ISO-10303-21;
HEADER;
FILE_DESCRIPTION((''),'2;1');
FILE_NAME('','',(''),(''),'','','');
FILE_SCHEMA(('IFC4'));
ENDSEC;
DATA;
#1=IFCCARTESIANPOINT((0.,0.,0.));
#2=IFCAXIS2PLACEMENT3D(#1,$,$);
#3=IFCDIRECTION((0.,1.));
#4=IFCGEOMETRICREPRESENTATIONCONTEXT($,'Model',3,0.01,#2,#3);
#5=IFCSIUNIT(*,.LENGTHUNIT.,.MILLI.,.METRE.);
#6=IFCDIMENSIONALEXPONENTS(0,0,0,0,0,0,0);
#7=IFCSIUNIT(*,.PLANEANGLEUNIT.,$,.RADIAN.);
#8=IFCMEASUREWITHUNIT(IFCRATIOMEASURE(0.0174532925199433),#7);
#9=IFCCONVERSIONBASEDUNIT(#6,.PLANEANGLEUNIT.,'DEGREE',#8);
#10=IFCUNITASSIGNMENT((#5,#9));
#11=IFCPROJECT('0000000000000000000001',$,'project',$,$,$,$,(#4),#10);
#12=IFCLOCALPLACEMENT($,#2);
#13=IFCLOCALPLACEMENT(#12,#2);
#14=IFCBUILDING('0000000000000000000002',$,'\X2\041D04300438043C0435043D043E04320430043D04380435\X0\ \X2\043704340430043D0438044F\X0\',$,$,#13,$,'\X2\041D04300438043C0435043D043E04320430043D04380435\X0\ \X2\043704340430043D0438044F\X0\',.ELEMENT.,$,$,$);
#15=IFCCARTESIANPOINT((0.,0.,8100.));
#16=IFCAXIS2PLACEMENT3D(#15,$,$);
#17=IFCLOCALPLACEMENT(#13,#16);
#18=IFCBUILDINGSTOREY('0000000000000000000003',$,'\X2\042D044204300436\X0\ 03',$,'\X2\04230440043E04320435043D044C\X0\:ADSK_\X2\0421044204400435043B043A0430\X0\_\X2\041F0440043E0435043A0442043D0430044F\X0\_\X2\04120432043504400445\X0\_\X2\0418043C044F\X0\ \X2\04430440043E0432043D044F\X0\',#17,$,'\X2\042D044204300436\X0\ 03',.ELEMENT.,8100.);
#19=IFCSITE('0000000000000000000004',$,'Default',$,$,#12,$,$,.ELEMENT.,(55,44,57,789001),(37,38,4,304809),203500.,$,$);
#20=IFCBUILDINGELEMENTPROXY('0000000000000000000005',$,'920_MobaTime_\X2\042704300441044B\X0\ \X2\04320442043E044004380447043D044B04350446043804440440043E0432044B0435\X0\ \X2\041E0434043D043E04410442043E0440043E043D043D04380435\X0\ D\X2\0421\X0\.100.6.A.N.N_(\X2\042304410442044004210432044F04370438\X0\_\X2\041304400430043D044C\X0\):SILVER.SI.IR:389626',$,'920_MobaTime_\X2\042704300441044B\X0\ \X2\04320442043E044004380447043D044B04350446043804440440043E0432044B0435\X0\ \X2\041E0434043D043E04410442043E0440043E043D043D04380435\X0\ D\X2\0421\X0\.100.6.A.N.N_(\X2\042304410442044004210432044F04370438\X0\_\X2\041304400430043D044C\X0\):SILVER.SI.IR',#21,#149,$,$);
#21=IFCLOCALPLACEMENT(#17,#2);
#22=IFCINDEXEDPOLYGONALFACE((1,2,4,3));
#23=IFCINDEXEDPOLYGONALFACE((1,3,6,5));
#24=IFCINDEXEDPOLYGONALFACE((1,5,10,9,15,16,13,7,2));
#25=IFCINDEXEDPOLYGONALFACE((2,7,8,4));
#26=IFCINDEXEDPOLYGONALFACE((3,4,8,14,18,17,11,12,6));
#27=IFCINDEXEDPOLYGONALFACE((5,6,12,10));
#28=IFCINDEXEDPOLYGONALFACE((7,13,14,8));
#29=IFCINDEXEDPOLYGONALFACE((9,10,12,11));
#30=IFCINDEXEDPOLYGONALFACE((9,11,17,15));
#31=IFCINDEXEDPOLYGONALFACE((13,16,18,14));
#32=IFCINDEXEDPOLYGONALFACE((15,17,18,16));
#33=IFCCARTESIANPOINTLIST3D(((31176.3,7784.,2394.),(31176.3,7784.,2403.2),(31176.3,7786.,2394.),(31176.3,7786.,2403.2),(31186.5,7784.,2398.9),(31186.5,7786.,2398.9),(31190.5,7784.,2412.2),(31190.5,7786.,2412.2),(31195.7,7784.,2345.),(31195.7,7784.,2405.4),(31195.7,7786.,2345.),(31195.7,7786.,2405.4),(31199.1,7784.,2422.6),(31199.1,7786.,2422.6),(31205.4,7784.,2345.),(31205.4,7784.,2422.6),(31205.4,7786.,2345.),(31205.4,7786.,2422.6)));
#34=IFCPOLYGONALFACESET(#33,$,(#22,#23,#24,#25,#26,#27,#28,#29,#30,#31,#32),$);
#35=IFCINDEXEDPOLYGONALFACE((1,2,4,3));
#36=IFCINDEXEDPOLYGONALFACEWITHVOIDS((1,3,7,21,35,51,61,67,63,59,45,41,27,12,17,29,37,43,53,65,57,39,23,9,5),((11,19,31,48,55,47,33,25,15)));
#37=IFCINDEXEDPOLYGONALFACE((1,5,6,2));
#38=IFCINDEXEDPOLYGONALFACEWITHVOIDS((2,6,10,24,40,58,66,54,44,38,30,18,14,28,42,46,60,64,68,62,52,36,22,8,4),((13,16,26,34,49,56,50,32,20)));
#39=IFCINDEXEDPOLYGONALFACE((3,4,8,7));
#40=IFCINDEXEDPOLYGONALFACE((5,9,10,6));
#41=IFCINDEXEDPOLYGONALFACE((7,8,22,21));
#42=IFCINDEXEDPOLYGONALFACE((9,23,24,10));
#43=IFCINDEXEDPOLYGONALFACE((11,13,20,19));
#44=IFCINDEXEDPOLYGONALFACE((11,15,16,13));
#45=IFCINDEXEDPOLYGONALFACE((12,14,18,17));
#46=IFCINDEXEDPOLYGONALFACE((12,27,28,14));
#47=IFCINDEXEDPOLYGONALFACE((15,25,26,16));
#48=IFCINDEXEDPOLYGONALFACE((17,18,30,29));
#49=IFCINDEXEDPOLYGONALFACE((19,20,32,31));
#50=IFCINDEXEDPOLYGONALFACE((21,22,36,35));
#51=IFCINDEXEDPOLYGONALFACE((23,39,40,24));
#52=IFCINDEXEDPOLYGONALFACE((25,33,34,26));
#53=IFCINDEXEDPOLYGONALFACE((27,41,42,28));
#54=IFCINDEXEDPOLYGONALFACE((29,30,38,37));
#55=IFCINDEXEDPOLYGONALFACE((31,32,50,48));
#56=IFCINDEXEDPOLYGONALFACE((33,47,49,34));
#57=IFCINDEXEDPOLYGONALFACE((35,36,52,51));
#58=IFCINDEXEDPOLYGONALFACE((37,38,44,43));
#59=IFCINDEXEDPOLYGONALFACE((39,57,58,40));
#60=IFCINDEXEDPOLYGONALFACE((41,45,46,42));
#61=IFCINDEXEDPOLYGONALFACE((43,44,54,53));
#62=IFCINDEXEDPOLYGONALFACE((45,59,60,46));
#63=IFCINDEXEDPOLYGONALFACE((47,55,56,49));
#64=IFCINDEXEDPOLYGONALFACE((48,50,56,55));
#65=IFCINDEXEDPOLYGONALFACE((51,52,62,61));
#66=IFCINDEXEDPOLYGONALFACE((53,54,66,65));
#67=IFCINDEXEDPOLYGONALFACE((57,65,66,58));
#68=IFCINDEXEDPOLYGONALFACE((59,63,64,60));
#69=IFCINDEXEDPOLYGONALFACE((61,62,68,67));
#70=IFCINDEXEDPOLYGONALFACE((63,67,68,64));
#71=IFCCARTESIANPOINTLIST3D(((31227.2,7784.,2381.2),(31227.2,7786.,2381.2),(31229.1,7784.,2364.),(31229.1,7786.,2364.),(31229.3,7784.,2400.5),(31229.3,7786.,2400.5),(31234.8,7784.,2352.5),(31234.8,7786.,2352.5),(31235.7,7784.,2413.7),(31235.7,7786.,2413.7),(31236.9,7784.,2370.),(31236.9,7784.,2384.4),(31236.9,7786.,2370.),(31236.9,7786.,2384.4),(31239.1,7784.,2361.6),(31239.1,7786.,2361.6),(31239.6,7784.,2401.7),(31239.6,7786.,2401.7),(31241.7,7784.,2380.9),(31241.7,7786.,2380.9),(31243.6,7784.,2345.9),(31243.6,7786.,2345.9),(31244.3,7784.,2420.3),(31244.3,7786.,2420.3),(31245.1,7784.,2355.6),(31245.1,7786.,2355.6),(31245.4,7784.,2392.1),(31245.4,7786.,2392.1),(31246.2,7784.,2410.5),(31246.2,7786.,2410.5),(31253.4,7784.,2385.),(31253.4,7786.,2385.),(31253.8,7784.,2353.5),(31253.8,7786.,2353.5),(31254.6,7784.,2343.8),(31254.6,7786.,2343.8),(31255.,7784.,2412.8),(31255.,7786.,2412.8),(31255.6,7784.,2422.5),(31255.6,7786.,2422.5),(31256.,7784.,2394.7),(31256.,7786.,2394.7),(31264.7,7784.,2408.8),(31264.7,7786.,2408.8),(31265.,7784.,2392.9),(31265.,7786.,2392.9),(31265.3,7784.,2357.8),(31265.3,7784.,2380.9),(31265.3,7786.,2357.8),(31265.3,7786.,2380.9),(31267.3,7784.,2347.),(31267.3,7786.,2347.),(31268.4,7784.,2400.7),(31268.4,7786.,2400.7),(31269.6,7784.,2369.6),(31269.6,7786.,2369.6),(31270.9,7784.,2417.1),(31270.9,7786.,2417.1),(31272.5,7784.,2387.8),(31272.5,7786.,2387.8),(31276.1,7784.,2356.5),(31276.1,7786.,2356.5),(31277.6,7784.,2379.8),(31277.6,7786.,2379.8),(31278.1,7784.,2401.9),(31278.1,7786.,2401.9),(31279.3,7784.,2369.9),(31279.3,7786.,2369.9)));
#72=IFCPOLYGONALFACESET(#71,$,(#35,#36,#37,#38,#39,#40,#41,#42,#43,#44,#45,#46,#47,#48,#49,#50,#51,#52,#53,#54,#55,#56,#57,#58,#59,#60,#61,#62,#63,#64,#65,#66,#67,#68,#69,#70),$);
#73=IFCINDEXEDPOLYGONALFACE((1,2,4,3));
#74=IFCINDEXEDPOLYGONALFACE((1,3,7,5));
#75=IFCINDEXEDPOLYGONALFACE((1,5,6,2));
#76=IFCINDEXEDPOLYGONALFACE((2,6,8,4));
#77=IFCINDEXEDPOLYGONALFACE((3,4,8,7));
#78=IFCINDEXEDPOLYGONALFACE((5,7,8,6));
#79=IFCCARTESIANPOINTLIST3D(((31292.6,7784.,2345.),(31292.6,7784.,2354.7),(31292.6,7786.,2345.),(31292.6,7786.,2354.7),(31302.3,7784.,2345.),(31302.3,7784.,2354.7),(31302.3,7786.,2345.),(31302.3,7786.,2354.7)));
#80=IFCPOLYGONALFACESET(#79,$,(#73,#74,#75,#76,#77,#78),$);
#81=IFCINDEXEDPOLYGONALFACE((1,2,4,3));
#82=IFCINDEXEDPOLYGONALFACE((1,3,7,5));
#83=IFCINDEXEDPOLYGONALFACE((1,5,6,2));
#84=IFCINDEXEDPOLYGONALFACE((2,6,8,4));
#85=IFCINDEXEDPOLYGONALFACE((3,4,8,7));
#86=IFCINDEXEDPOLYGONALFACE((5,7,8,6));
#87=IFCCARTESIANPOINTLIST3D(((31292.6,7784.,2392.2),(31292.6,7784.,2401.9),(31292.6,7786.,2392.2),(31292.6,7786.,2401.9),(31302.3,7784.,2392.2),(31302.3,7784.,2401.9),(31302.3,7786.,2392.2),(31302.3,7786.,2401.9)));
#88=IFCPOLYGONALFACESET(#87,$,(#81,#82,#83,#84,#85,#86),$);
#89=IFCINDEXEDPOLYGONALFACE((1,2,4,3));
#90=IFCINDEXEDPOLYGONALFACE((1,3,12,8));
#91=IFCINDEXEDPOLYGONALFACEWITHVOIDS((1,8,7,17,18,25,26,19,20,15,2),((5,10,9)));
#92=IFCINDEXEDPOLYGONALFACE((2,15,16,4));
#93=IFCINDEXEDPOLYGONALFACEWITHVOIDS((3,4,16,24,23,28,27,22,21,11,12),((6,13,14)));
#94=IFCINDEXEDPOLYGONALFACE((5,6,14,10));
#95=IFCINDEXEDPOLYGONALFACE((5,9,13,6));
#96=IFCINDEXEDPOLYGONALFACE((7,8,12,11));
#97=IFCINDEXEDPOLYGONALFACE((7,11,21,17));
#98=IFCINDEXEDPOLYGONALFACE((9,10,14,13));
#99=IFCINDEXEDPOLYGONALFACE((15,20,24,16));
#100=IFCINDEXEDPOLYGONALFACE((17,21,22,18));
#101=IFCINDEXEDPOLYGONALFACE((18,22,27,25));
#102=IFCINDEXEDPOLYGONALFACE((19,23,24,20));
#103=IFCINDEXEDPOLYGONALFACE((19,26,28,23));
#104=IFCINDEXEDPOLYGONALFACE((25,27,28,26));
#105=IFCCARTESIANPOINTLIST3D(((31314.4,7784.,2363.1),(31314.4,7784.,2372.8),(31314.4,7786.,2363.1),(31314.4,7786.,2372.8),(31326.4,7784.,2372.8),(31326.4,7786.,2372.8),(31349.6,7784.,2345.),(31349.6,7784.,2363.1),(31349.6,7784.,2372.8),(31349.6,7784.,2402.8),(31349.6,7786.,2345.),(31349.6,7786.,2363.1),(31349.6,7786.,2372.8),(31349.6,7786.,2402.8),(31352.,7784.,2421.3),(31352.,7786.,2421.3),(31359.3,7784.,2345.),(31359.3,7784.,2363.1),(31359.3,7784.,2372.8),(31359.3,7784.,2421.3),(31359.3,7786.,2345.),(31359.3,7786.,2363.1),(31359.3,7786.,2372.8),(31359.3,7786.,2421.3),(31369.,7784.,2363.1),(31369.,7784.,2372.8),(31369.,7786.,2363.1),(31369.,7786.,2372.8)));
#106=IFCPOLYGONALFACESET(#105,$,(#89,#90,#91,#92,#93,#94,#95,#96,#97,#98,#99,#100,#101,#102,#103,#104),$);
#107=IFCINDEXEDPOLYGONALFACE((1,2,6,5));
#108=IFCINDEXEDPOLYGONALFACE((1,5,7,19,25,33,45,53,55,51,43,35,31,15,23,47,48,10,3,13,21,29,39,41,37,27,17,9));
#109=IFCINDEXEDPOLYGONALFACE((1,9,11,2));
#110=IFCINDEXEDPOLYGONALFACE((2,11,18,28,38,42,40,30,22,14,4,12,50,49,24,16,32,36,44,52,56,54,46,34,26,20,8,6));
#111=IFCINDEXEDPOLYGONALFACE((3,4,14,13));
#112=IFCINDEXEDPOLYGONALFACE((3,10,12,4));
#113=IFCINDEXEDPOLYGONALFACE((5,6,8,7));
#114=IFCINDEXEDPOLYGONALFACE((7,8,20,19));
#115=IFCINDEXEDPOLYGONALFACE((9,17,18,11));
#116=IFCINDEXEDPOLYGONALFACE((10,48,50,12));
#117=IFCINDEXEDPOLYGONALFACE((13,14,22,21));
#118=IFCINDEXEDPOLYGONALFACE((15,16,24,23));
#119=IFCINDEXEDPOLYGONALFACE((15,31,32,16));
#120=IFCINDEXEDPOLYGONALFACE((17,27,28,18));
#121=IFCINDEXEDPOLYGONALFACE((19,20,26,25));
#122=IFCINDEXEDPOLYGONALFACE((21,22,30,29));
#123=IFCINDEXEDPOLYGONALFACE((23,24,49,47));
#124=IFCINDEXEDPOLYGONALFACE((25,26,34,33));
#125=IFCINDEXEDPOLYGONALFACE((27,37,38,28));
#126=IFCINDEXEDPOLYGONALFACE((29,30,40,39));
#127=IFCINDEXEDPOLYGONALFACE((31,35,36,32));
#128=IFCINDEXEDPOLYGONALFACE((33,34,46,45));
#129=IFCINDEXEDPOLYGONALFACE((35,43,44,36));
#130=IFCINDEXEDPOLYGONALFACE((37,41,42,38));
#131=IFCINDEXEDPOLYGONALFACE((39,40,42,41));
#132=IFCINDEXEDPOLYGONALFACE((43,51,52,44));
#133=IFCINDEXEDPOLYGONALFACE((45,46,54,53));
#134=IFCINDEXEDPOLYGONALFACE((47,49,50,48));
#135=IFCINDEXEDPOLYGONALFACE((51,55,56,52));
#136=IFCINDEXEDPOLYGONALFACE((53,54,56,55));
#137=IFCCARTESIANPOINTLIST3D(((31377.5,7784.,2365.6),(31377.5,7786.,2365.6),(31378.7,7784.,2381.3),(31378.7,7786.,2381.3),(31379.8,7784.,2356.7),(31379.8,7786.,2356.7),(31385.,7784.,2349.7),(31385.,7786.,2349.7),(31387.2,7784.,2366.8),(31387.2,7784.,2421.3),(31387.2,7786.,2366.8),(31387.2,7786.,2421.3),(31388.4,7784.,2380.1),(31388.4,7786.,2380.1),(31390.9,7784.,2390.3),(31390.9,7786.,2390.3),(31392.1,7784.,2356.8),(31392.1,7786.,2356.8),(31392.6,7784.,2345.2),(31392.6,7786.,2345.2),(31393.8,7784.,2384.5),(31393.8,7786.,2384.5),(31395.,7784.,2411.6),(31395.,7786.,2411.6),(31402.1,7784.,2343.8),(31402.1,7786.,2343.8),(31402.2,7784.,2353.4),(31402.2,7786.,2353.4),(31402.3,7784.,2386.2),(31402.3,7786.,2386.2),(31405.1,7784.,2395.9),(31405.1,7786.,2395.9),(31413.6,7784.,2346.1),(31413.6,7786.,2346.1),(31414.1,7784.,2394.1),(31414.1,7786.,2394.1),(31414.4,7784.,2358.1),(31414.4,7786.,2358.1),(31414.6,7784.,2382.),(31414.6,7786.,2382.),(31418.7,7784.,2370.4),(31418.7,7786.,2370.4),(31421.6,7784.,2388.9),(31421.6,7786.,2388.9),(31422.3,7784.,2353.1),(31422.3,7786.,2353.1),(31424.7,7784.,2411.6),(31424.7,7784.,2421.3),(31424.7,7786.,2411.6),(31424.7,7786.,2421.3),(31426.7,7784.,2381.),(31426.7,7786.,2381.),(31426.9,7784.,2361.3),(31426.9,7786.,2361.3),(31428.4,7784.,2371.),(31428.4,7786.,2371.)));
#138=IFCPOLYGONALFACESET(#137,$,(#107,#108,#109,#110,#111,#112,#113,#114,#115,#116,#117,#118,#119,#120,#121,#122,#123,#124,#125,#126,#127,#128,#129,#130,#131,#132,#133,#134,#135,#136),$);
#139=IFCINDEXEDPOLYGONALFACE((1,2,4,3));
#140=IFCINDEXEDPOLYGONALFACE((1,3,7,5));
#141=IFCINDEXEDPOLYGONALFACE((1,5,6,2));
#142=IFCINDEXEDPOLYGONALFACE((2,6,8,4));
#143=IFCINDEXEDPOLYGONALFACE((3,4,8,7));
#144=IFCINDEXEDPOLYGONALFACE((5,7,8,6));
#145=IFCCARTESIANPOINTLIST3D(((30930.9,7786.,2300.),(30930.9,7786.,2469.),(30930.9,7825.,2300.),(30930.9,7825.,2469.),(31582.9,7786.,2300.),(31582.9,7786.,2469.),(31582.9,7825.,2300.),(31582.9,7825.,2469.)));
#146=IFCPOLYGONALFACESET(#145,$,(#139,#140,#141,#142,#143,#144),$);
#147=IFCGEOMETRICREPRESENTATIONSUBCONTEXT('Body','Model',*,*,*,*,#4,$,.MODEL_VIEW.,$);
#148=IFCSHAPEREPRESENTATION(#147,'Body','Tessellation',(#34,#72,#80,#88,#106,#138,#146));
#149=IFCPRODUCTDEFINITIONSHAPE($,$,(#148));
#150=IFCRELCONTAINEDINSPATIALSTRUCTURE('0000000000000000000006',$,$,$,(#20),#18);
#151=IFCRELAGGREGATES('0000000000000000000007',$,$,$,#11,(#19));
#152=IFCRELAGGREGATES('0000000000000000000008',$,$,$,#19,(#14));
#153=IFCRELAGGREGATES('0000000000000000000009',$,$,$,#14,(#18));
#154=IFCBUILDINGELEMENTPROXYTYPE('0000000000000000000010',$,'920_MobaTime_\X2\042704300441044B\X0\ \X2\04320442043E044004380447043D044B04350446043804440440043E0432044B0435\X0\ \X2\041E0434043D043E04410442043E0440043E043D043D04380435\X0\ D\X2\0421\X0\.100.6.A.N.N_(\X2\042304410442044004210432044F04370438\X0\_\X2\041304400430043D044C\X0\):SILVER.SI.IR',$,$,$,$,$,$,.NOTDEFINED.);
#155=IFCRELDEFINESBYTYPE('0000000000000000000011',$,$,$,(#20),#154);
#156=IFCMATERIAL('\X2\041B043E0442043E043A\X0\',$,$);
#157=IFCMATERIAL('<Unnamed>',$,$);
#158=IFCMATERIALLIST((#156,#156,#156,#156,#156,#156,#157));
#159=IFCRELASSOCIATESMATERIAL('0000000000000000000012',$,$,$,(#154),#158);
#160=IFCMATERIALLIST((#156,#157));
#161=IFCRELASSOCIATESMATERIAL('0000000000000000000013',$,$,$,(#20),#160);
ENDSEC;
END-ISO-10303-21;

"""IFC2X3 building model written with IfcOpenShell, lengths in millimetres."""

from ifc_helpers import new_model, entity, si_unit, converted_unit, direction, frame, origin, origin_2d_with_axis, place, context, subcontext, project, spatial, polyline, rectangle, outline, extrude, source, transform, mapped, material, material_list, type_object, type_shapes, element, save


model = new_model("IFC2X3")

# Units and contexts
model_context = context("Model", 3, precision=0.01, world=origin(), true_north=direction((0.0, 1.0)))
body_context = subcontext(model_context, "Body", "Model", "MODEL_VIEW")
ifc_project = project(units=[si_unit("LENGTHUNIT", "METRE", prefix="MILLI"), converted_unit("PLANEANGLEUNIT", "DEGREE", entity("IfcRatioMeasure", 0.0174532925199433), si_unit("PLANEANGLEUNIT", "RADIAN"), dimensions=[0, 0, 0, 0, 0, 0, 0])], contexts=[model_context])

# Site, building, storey
site_placement = place(None, origin())
site = spatial("IfcSite", under=ifc_project, at=site_placement, Name="Default", CompositionType="ELEMENT", RefLatitude=(55, 44, 57, 789001), RefLongitude=(37, 38, 4, 304809), RefElevation=203500.0)
building_placement = place(site_placement, origin())
building = spatial("IfcBuilding", under=site, at=building_placement, Name="Наименование здания", LongName="Наименование здания", CompositionType="ELEMENT")
storey_placement = place(building_placement, frame((0.0, 0.0, 8100.0)))
storey = spatial("IfcBuildingStorey", under=building, at=storey_placement, Name="Этаж 03", ObjectType="Уровень:ADSK_Стрелка_Проектная_Вверх_Имя уровня", LongName="Этаж 03", CompositionType="ELEMENT", Elevation=8100.0)

# Building element proxy
ifc_material_1 = material(Name="Лоток")
ifc_material_2 = material(Name="<Unnamed>")
ifc_material_list_1 = material_list([ifc_material_1, ifc_material_1, ifc_material_1, ifc_material_1, ifc_material_1, ifc_material_1, ifc_material_2])
building_element_proxy_type = type_object("IfcBuildingElementProxyType", Name="920_MobaTime_Часы вторичныецифровые Односторонние DС.100.6.A.N.N_(УстрСвязи_Грань):SILVER.SI.IR", PredefinedType="NOTDEFINED", material=ifc_material_list_1)
shared_shape = source(origin(), body_context, "Body", "SweptSolid", [
    extrude(outline(polyline([(-49.3, -13.1), (28.2, -13.1), (28.2, -6.8), (17.9, 1.8), (8.8, 16.0), (-0.3, 16.0), (4.6, 5.8), (11.1, -3.4), (-49.3, -3.4), (-49.3, -13.1)])), frame((-64.6, 9.8, 39.0), z_axis=(0.0, 0.0, 1.0), x_axis=(0.0, 1.0, 0.0)), (0.0, 0.0, 1.0), 2.0),
    extrude(outline(polyline([(2.2, -27.6), (19.0, -27.6), (30.5, -16.1), (33.3, -4.9), (31.0, 5.8), (21.8, 17.2), (5.2, 27.3), (-11.1, 33.0), (-24.0, 32.7), (-33.6, 27.6), (-40.3, 18.6), (-42.8, 5.7), (-38.0, -6.3), (-27.2, -14.9), (-17.5, -17.7), (-8.2, -16.4), (-0.3, -11.9), (5.1, -4.5), (7.3, 6.2), (4.0, 17.2), (18.4, 7.3), (23.6, -2.4), (22.0, -11.4), (14.2, -18.4), (5.3, -18.3), (2.2, -27.6)]), holes=[polyline([(-9.0, 23.3), (-1.3, 14.3), (-2.5, 2.0), (-11.4, -7.0), (-23.4, -6.0), (-32.2, 2.9), (-31.2, 15.1), (-25.6, 22.1), (-17.5, 24.9), (-9.0, 23.3)])]), frame((-2.7, 3.6, 39.0), z_axis=(0.0, 0.0, 1.0), x_axis=(-0.427649, 0.903945, 0.0)), (0.0, 0.0, 1.0), 2.0),
    extrude(rectangle(XDim=9.7, YDim=9.7, at=origin_2d_with_axis()), frame((40.6, -34.7, 39.0)), (0.0, 0.0, 1.0), 2.0),
    extrude(rectangle(XDim=9.7, YDim=9.7, at=origin_2d_with_axis()), frame((40.6, 12.6, 39.0)), (0.0, 0.0, 1.0), 2.0),
    extrude(outline(polyline([(-0.9, -28.1), (8.8, -28.1), (8.8, -9.9), (18.5, -9.9), (18.5, -0.2), (8.8, -0.2), (8.8, 48.3), (1.5, 48.3), (-36.0, -0.2), (-36.0, -9.9), (-0.9, -9.9), (-0.9, -28.1)]), holes=[polyline([(-0.9, -0.2), (-24.1, -0.2), (-0.9, 29.7), (-0.9, -0.2)])]), frame((93.6, -11.4, 39.0)), (0.0, 0.0, 1.0), 2.0),
    extrude(outline(polyline([(3.3, -28.3), (12.5, -28.3), (20.5, -25.0), (26.8, -18.9), (30.7, -10.0), (31.4, 1.6), (26.9, 11.8), (20.1, 18.4), (11.1, 22.3), (1.0, 23.3), (-7.9, 20.4), (-14.9, 14.5), (-18.9, 6.2), (-17.1, -9.0), (-36.7, 0.5), (-29.1, 29.2), (-38.5, 31.7), (-48.1, -4.6), (-11.6, -23.1), (-8.0, -14.0), (-10.8, -7.6), (-10.2, 1.1), (-3.0, 11.8), (9.2, 12.8), (20.0, 5.5), (21.4, -7.5), (15.5, -16.4), (4.6, -18.6), (3.3, -28.3)])), frame((147.1, -8.5, 39.0), z_axis=(0.0, 0.0, 1.0), x_axis=(0.256974, -0.966418, 0.0)), (0.0, 0.0, 1.0), 2.0),
    extrude(rectangle(XDim=652.0, YDim=169.0, at=origin_2d_with_axis()), frame((0.0, 0.0, 0.0), z_axis=(0.0, 0.0, 1.0), x_axis=(-1.0, 0.0, 0.0)), (0.0, 0.0, 1.0), 39.0),
])
type_shapes(building_element_proxy_type, [shared_shape])
ifc_material_list_2 = material_list([ifc_material_1, ifc_material_2])
for number, where, z_axis, x_axis, name in (
    (1, (31256.9, 7825.0, 2384.5), (0.0, -1.0, 0.0), (1.0, 0.0, 0.0), "920_MobaTime_Часы вторичныецифровые Односторонние DС.100.6.A.N.N_(УстрСвязи_Грань):SILVER.SI.IR:389626"),
):
    element("IfcBuildingElementProxy", number, at=place(storey_placement, frame(where, z_axis=z_axis, x_axis=x_axis)), inside=storey, type_object=building_element_proxy_type, material=ifc_material_list_2, Name=name, ObjectType="920_MobaTime_Часы вторичныецифровые Односторонние DС.100.6.A.N.N_(УстрСвязи_Грань):SILVER.SI.IR", context=body_context, shape_type="MappedRepresentation", body=[
        mapped(shared_shape, transform((0.0, 0.0, 0.0), scale=1.0)),
    ])

save(model, "model.ifc")
